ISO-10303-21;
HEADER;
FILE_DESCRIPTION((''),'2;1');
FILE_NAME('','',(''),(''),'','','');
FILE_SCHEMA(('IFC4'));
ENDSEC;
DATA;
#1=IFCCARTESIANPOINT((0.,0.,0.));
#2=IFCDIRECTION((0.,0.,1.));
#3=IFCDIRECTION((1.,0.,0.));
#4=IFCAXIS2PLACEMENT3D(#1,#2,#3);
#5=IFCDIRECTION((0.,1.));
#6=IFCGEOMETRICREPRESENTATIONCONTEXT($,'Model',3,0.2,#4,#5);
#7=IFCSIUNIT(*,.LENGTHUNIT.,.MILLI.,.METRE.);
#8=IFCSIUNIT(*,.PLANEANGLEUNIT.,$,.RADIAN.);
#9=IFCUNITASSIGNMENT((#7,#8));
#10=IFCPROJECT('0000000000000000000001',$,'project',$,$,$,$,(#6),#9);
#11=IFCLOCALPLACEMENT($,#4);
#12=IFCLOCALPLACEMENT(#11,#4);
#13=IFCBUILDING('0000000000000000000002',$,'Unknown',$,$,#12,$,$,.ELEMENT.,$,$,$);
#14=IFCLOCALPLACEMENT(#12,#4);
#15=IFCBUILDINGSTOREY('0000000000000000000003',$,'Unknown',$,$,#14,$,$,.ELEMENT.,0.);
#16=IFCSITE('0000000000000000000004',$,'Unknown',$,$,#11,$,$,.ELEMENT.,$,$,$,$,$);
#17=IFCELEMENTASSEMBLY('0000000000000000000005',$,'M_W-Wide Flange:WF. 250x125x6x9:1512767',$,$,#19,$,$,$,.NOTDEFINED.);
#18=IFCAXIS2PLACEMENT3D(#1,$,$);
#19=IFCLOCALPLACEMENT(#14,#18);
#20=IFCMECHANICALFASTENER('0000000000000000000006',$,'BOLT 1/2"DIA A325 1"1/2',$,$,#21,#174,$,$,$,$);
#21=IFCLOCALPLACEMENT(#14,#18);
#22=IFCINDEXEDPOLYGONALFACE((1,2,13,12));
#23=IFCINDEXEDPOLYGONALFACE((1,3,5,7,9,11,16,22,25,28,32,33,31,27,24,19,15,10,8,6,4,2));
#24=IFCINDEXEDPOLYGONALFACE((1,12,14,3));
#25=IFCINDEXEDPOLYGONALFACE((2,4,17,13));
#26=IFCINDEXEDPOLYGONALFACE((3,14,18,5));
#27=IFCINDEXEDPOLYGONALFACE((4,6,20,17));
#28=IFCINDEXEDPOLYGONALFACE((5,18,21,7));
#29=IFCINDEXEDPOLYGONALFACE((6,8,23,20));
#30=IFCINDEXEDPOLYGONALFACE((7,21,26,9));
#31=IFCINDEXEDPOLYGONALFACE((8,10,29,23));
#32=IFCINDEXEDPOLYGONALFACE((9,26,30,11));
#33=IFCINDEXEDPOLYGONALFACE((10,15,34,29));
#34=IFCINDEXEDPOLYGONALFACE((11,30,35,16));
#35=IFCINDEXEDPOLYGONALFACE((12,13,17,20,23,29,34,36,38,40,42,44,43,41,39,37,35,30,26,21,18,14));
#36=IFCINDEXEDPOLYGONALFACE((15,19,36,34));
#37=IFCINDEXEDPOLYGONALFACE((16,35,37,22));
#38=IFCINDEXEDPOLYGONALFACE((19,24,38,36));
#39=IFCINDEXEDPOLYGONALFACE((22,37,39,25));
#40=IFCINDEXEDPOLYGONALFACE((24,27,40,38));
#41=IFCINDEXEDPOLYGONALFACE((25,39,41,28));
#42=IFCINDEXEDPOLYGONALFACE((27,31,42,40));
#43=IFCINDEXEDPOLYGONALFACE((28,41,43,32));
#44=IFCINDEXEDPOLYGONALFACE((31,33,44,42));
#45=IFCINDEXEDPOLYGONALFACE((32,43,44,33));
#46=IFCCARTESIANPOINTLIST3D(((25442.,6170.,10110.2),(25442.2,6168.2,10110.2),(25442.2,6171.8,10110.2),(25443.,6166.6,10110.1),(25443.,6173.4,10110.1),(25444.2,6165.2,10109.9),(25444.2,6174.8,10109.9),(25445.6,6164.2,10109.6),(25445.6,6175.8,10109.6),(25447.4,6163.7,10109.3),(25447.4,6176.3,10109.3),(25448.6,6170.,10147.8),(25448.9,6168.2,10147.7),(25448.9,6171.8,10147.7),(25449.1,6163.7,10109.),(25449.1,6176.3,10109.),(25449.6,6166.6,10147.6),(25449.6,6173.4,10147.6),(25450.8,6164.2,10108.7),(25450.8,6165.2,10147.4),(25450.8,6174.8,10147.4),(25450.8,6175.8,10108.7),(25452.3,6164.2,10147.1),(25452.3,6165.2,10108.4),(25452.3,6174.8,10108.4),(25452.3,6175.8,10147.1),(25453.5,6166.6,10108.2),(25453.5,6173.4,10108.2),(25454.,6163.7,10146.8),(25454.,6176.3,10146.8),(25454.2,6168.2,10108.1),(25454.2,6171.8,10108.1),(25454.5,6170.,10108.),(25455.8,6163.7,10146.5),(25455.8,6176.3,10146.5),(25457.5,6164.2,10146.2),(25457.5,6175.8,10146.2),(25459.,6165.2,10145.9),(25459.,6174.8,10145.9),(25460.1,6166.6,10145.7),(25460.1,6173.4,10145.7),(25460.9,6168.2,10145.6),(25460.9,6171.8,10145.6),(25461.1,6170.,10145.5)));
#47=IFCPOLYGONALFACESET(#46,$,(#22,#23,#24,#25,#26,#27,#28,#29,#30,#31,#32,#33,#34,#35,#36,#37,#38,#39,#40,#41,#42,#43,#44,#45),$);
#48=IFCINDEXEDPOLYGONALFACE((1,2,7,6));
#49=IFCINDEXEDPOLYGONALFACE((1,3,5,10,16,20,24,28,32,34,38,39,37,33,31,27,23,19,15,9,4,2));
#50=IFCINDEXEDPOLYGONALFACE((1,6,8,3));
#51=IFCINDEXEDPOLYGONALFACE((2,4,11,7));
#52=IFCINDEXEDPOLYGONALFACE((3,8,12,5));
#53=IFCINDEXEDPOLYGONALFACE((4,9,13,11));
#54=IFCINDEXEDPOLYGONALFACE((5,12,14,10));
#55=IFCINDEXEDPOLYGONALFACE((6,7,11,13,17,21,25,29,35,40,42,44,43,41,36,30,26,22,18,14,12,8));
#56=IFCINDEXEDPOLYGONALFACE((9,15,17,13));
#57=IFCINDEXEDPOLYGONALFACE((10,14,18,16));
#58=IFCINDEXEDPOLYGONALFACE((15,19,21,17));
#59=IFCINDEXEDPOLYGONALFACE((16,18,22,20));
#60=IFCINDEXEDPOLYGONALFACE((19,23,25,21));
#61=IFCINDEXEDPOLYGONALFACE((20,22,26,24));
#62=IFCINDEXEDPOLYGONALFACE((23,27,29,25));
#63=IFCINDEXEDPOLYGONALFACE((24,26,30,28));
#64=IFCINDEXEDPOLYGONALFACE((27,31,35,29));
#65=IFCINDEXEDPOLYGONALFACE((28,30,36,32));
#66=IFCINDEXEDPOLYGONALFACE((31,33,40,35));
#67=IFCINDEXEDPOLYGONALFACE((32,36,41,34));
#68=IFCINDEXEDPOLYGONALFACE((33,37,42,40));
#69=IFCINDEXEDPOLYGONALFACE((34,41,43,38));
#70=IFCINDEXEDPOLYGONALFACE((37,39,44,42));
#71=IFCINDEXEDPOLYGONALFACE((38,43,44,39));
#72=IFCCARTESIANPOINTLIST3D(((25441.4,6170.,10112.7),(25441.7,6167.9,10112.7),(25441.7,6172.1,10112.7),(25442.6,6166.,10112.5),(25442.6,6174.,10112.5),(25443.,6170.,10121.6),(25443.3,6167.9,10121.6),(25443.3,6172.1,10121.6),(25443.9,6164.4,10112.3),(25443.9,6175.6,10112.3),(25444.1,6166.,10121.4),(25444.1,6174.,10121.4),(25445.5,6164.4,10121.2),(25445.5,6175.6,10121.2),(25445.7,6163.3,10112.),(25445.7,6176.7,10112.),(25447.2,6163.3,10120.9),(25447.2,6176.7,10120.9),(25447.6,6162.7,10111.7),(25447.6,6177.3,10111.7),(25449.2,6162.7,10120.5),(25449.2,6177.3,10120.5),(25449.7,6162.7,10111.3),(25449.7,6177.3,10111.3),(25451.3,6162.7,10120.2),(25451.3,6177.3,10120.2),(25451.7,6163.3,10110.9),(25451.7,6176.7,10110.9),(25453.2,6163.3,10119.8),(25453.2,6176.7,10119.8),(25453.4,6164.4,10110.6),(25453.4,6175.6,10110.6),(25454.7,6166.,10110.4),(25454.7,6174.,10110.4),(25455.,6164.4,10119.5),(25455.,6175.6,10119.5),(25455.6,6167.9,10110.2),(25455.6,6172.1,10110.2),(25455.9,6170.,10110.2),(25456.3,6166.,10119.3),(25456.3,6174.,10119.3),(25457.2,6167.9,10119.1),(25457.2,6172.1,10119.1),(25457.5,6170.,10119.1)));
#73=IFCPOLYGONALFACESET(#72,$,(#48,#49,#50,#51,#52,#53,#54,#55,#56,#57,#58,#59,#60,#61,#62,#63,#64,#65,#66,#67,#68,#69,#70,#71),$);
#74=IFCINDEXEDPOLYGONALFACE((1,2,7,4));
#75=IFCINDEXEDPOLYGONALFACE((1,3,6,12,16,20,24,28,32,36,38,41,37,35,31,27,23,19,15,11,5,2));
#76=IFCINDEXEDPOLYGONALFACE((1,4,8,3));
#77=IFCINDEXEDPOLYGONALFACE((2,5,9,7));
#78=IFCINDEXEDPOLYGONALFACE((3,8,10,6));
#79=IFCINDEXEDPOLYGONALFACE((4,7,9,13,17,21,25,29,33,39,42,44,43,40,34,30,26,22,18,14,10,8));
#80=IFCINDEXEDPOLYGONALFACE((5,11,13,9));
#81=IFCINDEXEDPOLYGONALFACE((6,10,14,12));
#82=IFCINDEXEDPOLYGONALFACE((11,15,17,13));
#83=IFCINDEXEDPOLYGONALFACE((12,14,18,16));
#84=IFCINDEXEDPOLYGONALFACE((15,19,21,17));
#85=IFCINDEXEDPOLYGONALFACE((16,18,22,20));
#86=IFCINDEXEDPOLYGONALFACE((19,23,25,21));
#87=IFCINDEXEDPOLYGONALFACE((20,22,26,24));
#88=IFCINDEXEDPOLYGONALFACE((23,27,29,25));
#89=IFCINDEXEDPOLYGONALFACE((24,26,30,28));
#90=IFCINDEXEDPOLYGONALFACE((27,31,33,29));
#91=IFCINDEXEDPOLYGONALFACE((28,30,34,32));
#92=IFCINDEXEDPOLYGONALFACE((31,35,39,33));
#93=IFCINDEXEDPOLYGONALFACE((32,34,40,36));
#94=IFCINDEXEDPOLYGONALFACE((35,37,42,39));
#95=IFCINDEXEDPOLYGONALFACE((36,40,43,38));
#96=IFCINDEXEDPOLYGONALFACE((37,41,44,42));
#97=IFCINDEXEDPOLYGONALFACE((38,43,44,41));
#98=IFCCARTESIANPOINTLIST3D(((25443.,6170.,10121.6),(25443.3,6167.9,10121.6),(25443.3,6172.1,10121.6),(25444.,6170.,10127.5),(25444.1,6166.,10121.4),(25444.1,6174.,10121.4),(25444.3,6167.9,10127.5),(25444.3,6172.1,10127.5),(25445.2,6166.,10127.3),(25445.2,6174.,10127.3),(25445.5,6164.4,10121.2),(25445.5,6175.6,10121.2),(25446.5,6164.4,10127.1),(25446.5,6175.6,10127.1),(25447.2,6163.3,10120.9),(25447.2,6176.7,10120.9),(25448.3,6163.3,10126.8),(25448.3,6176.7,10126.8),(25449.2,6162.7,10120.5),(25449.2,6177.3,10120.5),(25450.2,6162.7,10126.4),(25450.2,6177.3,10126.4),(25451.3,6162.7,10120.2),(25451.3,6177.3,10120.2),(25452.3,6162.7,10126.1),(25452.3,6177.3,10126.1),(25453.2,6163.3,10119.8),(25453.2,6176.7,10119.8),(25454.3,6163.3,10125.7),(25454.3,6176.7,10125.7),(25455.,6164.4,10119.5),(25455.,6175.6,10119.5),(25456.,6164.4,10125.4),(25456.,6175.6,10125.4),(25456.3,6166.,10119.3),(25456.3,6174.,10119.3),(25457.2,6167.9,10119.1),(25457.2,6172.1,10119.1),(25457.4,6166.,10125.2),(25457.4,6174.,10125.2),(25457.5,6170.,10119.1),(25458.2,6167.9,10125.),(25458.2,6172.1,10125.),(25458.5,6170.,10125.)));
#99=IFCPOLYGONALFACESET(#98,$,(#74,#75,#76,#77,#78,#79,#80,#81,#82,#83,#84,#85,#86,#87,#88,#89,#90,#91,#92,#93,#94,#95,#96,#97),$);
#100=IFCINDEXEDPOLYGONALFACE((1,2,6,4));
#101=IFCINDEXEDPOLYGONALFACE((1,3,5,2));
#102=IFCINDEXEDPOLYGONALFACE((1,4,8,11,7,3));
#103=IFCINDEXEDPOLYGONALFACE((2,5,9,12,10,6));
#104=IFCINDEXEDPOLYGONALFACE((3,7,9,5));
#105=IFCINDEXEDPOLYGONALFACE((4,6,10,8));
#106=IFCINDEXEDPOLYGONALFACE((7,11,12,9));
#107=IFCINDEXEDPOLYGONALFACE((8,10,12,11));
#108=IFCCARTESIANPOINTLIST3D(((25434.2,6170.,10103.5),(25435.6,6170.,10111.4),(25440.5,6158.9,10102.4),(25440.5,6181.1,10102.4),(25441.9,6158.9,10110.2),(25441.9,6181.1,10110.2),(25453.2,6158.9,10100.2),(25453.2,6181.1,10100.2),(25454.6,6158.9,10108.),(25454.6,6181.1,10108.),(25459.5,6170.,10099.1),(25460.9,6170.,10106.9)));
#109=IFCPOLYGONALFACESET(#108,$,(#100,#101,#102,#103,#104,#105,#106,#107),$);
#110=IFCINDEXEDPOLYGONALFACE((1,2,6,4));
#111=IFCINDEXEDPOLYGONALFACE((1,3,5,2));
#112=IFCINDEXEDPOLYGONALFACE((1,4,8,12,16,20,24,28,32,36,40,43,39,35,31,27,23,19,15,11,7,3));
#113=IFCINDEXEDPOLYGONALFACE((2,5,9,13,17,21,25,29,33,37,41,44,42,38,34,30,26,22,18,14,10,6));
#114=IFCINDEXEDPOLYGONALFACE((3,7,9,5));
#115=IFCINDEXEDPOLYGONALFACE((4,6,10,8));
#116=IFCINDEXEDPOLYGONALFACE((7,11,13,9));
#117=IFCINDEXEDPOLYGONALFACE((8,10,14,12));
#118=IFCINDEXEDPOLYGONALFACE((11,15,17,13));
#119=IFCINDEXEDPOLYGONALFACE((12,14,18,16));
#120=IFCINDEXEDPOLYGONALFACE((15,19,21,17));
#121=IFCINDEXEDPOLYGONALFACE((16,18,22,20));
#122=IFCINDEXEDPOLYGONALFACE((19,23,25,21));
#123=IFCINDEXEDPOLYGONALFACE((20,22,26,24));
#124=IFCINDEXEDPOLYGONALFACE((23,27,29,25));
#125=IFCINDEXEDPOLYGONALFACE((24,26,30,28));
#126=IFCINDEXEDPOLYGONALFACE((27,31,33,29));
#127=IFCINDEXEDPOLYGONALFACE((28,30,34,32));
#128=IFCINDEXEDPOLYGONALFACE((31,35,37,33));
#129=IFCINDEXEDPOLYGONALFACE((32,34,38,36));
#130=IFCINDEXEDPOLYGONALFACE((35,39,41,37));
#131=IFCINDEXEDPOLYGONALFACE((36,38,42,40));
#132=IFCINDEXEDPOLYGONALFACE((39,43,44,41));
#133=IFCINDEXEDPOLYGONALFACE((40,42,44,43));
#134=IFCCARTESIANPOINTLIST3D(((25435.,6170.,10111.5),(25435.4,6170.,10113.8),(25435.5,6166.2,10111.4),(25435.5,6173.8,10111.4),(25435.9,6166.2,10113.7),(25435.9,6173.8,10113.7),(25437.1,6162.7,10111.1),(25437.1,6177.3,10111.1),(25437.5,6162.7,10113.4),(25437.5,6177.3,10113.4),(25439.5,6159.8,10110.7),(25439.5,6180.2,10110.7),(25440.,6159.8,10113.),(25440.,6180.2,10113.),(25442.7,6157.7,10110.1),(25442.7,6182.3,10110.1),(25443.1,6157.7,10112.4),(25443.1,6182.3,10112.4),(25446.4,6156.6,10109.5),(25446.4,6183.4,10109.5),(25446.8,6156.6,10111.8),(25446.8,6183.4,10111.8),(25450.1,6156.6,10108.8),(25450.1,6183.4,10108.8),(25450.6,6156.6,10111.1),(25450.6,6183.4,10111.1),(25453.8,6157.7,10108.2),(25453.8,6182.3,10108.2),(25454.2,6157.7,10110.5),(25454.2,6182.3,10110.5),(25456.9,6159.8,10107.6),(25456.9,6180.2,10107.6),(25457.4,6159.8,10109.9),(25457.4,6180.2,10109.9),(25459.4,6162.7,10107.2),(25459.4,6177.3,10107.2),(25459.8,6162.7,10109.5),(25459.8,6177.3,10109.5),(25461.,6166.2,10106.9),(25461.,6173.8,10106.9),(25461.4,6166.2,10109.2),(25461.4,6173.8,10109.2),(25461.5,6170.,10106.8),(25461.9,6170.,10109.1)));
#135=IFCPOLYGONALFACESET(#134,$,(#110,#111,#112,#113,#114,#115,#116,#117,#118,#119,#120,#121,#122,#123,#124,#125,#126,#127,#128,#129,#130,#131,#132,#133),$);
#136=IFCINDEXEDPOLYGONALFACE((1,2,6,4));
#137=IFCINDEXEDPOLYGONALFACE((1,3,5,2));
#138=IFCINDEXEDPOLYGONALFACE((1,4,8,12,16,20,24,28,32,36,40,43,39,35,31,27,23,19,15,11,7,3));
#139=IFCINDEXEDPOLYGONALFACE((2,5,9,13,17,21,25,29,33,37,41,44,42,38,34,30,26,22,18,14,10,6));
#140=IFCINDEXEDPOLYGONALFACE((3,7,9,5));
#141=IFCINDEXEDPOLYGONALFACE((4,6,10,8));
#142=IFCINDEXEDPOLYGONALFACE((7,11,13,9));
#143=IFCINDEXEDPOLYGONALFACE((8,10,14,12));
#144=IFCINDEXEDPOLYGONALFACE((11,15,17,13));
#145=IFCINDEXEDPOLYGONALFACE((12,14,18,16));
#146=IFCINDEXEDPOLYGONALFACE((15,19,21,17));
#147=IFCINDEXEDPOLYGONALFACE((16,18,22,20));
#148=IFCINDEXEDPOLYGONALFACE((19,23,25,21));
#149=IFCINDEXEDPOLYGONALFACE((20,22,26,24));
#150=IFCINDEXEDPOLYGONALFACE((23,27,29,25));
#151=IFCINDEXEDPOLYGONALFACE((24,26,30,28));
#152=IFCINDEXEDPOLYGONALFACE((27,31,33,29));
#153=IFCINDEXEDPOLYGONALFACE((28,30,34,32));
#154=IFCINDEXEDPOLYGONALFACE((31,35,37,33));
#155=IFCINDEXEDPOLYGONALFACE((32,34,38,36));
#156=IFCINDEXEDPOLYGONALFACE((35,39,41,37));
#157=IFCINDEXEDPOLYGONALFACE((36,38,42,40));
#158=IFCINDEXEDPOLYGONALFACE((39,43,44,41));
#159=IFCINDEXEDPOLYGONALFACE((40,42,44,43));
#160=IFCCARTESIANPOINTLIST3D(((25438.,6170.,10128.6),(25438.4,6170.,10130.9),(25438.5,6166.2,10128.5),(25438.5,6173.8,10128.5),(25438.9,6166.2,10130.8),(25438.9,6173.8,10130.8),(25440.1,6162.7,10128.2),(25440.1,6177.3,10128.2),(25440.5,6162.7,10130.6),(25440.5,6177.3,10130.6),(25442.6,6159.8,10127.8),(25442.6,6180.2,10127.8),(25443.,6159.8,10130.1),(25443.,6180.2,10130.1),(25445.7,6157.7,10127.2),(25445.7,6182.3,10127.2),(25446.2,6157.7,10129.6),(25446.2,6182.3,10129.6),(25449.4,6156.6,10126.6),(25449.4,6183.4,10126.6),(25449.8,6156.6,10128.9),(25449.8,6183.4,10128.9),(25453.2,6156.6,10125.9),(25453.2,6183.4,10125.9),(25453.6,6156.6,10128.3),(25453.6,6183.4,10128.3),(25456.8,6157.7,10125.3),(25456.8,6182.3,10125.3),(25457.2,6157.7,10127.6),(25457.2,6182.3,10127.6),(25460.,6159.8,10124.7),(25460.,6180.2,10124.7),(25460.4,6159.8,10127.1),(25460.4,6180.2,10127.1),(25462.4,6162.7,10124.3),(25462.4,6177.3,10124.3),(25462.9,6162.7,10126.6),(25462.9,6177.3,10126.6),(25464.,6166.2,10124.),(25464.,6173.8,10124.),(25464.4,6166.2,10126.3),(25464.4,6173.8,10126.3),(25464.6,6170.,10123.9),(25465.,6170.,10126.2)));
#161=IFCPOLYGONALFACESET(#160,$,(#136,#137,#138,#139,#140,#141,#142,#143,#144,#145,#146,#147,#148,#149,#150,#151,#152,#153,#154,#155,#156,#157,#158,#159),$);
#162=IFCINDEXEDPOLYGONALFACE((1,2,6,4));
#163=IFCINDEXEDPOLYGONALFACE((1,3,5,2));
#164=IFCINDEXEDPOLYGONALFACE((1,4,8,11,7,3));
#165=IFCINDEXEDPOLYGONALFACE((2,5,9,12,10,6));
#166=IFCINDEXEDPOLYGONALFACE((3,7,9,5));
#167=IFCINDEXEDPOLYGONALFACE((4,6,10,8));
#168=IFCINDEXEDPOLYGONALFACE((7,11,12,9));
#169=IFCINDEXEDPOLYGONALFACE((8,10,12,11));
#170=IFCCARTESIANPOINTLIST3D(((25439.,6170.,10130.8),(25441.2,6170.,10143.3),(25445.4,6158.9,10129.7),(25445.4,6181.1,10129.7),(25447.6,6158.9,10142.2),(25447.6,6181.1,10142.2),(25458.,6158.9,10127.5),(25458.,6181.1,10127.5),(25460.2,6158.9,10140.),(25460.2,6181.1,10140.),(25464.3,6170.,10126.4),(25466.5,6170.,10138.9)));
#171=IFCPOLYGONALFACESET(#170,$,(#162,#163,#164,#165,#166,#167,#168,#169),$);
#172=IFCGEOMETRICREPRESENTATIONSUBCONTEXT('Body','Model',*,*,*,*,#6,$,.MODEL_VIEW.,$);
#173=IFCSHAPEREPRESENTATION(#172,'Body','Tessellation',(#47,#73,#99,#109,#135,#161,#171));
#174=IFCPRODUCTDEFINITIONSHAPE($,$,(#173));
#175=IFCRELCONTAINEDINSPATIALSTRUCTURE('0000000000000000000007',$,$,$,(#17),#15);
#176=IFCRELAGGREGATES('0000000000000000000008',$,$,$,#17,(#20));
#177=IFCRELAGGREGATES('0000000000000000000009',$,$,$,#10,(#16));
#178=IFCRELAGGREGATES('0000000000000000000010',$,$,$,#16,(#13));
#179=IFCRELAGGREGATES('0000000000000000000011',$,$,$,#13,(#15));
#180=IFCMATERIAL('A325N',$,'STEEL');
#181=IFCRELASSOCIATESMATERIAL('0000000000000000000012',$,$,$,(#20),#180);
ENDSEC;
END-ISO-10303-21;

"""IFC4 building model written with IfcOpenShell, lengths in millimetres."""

from ifc_helpers import new_model, si_unit, direction, frame, origin_with_axes, place, context, subcontext, project, spatial, line, arc, indexed_curve, outline, extrude, source, transform, mapped, material, element, aggregate, save


model = new_model("IFC4")

# Units and contexts
model_context = context("Model", 3, precision=0.2, world=origin_with_axes(), true_north=direction((0.0, 1.0)))
body_context = subcontext(model_context, "Body", "Model", "MODEL_VIEW")
ifc_project = project(units=[si_unit("LENGTHUNIT", "METRE", prefix="MILLI"), si_unit("PLANEANGLEUNIT", "RADIAN")], contexts=[model_context])

# Site, building, storey
site_placement = place(None, origin_with_axes())
site = spatial("IfcSite", under=ifc_project, at=site_placement, Name="Unknown", CompositionType="ELEMENT")
building_placement = place(site_placement, origin_with_axes())
building = spatial("IfcBuilding", under=site, at=building_placement, Name="Unknown", CompositionType="ELEMENT")
storey_placement = place(building_placement, origin_with_axes())
storey = spatial("IfcBuildingStorey", under=building, at=storey_placement, Name="Unknown", CompositionType="ELEMENT", Elevation=0.0)

# Shared definitions
ifc_material_1 = material(Name="A325N", Category="STEEL")
shared_shape_1 = source(origin_with_axes(), body_context, "Body", "SweptSolid", [
    extrude(outline(indexed_curve([(6.3, 0.0), (0.0, 6.3), (-6.3, 0.0), (0.0, -6.3)], segments=[arc(1, 2, 3), arc(3, 4, 1)])), frame((0.0, 0.0, 17.4), z_axis=(0.0, 0.0, -1.0), x_axis=(0.0, 1.0, 0.0)), (0.0, 0.0, 1.0), 38.1),
    extrude(outline(indexed_curve([(7.3, 0.0), (0.0, 7.3), (-7.3, 0.0), (0.0, -7.3)], segments=[arc(1, 2, 3), arc(3, 4, 1)])), frame((0.0, 0.0, 15.0), z_axis=(0.0, 0.0, -1.0), x_axis=(0.0, 1.0, 0.0)), (0.0, 0.0, 1.0), 9.0),
    extrude(outline(indexed_curve([(7.3, 0.0), (0.0, 7.3), (-7.3, 0.0), (0.0, -7.3)], segments=[arc(1, 2, 3), arc(3, 4, 1)])), frame((0.0, 0.0, 6.0), z_axis=(0.0, 0.0, -1.0), x_axis=(0.0, 1.0, 0.0)), (0.0, 0.0, 1.0), 6.0),
    extrude(outline(indexed_curve([(12.8, 0.0), (6.4, 11.1), (-6.4, 11.1), (-12.8, 0.0), (-6.4, -11.1), (6.4, -11.1)], segments=[line(1, 2, 3, 4, 5, 6, 1)])), frame((0.0, 0.0, 25.3), z_axis=(0.0, 0.0, -1.0), x_axis=(0.0, 1.0, 0.0)), (0.0, 0.0, 1.0), 7.9),
    extrude(outline(indexed_curve([(13.5, 0.0), (0.0, 13.5), (-13.5, 0.0), (0.0, -13.5)], segments=[arc(1, 2, 3), arc(3, 4, 1)])), frame((0.0, 0.0, 17.4), z_axis=(0.0, 0.0, -1.0), x_axis=(0.0, 1.0, 0.0)), (0.0, 0.0, 1.0), 2.4),
    extrude(outline(indexed_curve([(13.5, 0.0), (0.0, 13.5), (-13.5, 0.0), (0.0, -13.5)], segments=[arc(1, 2, 3), arc(3, 4, 1)])), frame((0.0, 0.0, 0.0), z_axis=(0.0, 0.0, -1.0), x_axis=(0.0, 1.0, 0.0)), (0.0, 0.0, 1.0), 2.4),
    extrude(outline(indexed_curve([(12.8, 0.0), (6.4, 11.1), (-6.4, 11.1), (-12.8, 0.0), (-6.4, -11.1), (6.4, -11.1)], segments=[line(1, 2, 3, 4, 5, 6, 1)])), frame((0.0, 0.0, -2.4), z_axis=(0.0, 0.0, -1.0), x_axis=(0.0, 1.0, 0.0)), (0.0, 0.0, 1.0), 12.7),
])

# Element assembly, mechanical fastener
assembly_1_placement = place(storey_placement, frame((25460.5, 0.0, 9991.6), z_axis=(0.984808, 0.0, -0.173648), x_axis=(0.0, 1.0, 0.0)))
assembly_1 = element("IfcElementAssembly", 1, at=assembly_1_placement, inside=storey, Name="M_W-Wide Flange:WF. 250x125x6x9:1512767", PredefinedType="NOTDEFINED")
mechanical_fastener_1_placement = place(assembly_1_placement, frame((6170.0, 131.0, -32.5), z_axis=(0.0, -1.0, 0.0), x_axis=(-1.0, 0.0, 0.0)))
mechanical_fastener_1 = element("IfcMechanicalFastener", 2, at=mechanical_fastener_1_placement, material=ifc_material_1, Name="BOLT 1/2\"DIA A325 1\"1/2", context=body_context, shape_type="MappedRepresentation", body=[
    mapped(shared_shape_1, transform((0.0, 0.0, 0.0))),
])
aggregate(assembly_1, [mechanical_fastener_1])

save(model, "model.ifc")
